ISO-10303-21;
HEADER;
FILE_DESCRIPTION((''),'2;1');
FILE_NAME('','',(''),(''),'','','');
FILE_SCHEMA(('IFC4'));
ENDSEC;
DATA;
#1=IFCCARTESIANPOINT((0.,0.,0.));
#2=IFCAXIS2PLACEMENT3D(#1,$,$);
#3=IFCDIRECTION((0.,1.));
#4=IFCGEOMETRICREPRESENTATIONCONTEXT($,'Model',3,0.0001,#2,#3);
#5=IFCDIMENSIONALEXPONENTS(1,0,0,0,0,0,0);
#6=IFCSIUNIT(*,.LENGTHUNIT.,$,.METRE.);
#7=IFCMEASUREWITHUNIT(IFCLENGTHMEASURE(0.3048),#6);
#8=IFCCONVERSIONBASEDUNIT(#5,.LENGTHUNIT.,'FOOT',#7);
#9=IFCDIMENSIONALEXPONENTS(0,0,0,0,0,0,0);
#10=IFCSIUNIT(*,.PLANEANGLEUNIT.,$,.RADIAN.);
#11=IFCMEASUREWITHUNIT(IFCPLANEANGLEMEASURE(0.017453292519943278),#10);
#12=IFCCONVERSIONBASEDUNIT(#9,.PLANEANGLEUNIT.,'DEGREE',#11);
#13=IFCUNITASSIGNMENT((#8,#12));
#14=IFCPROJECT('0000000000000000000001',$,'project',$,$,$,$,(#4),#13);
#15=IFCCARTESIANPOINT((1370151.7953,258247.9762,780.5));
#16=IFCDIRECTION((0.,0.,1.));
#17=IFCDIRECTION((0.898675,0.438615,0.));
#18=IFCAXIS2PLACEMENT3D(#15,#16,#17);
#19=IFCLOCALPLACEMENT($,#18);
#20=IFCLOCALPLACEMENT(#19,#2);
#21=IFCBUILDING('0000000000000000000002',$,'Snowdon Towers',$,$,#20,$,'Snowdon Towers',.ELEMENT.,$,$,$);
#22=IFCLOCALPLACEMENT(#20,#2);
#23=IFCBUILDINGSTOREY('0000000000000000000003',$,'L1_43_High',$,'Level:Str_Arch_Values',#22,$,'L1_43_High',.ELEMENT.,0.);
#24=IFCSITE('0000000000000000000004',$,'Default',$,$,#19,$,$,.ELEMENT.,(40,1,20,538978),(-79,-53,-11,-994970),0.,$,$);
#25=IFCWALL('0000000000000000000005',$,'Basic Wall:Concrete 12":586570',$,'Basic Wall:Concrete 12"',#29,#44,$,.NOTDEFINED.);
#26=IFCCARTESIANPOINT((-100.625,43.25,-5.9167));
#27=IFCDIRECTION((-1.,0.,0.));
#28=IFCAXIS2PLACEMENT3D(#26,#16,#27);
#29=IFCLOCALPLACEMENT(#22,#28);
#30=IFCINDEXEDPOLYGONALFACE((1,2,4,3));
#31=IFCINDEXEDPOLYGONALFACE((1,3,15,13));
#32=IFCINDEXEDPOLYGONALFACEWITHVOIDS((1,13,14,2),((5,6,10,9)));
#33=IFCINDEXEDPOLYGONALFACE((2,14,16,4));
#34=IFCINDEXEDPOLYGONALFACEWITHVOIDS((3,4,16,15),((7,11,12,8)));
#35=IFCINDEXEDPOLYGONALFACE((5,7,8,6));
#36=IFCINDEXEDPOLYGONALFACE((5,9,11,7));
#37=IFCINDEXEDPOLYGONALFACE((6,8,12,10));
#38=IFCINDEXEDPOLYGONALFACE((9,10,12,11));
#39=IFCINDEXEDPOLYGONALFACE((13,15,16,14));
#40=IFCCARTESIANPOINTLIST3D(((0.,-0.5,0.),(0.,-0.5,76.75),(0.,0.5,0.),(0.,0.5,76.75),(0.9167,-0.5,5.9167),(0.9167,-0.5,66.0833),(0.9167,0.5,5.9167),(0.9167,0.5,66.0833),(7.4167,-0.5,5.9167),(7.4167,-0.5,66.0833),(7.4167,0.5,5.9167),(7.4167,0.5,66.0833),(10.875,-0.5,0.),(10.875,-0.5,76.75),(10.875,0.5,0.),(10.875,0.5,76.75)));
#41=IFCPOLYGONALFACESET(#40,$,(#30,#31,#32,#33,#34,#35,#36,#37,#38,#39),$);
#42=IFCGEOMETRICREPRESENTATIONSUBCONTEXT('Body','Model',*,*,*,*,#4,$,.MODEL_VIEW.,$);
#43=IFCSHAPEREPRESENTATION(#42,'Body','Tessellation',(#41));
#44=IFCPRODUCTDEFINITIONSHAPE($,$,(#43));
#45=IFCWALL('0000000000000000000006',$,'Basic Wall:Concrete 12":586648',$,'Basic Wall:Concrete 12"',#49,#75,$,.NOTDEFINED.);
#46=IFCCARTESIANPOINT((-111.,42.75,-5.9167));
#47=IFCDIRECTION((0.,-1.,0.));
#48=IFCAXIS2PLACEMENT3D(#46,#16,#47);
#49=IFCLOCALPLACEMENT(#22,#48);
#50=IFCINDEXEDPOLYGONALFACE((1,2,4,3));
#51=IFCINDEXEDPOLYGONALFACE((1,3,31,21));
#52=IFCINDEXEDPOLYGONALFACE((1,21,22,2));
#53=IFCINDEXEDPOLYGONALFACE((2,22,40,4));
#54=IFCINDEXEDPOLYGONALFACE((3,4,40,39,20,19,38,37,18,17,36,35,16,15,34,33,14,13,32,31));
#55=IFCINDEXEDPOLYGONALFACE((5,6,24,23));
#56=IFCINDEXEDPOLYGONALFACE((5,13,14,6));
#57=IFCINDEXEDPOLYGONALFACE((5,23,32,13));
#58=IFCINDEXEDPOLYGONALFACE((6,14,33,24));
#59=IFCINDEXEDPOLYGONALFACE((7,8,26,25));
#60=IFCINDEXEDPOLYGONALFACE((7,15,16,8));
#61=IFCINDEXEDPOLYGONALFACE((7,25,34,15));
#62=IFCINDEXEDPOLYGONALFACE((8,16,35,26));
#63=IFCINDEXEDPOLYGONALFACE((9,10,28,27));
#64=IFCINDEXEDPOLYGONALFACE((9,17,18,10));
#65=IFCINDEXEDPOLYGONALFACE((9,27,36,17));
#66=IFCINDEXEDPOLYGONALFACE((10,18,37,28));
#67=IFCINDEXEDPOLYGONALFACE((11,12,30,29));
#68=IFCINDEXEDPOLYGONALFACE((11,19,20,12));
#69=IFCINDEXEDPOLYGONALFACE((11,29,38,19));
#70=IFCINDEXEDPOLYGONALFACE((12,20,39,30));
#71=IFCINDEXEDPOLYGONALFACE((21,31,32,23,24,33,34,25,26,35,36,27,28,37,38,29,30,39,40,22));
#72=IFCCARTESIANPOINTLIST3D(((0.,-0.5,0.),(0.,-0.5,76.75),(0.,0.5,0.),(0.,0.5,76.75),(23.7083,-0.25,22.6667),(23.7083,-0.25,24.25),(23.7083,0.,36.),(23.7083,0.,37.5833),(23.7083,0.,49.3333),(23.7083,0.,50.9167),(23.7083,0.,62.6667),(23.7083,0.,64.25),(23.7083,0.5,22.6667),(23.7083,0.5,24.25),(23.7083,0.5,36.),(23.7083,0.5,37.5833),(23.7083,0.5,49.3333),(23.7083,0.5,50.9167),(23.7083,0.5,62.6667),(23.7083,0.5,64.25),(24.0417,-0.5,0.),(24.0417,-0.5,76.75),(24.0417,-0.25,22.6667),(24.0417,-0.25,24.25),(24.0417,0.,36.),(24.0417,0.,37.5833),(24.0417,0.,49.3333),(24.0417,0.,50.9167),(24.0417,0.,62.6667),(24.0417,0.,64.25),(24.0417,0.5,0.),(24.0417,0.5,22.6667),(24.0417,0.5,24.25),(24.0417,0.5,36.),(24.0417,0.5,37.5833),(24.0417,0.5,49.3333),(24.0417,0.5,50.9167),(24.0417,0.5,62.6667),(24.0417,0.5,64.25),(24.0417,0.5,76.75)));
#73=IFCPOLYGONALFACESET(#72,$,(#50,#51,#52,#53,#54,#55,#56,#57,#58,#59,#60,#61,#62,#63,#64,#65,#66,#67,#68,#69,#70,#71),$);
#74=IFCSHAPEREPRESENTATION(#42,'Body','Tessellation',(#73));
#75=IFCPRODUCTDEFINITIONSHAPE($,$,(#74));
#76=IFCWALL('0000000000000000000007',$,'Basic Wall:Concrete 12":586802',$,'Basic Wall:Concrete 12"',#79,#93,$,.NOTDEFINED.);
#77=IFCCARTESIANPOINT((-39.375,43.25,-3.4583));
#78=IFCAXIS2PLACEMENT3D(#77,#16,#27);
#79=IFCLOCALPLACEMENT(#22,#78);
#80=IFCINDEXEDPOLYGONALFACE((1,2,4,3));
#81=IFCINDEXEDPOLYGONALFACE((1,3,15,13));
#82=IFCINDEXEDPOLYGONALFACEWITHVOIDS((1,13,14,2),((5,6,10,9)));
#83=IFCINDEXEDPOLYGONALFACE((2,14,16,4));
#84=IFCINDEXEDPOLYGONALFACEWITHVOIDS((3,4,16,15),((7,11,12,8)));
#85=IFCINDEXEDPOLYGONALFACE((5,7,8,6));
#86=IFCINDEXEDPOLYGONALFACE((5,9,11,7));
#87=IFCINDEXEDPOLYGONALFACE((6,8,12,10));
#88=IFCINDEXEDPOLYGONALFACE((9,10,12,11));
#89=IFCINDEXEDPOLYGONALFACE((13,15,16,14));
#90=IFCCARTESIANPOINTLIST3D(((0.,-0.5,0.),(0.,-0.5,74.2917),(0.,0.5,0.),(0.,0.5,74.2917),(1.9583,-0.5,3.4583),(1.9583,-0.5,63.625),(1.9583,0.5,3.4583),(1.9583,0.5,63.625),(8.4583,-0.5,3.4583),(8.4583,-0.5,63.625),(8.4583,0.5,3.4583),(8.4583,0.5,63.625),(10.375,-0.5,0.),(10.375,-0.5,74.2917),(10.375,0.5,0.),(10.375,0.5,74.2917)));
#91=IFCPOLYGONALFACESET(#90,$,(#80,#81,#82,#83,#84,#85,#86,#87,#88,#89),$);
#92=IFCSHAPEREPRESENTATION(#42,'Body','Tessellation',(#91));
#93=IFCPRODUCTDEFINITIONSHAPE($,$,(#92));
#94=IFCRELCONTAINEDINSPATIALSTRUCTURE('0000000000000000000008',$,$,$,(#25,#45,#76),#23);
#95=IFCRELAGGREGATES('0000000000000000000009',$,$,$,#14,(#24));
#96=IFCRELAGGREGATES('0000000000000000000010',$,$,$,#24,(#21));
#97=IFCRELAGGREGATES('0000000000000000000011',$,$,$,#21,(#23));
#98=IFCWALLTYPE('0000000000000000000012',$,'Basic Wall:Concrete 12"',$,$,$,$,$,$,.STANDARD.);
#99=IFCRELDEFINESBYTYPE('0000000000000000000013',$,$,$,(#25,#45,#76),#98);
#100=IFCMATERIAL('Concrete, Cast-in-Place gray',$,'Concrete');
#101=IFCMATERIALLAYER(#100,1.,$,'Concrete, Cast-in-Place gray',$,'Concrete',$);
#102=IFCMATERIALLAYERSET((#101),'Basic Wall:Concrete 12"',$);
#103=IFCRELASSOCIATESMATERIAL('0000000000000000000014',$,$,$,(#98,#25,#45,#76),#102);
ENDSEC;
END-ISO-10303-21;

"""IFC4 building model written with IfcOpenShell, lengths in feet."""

from ifc_helpers import new_model, entity, si_unit, converted_unit, direction, frame, frame_2d, origin, place, context, subcontext, project, spatial, rectangle, extrude, material, layer, layer_set, layer_usage, type_object, element, save


model = new_model("IFC4")

# Units and contexts
model_context = context("Model", 3, precision=0.0001, world=origin(), true_north=direction((0.0, 1.0)))
body_context = subcontext(model_context, "Body", "Model", "MODEL_VIEW")
ifc_project = project(units=[converted_unit("LENGTHUNIT", "FOOT", entity("IfcLengthMeasure", 0.3048), si_unit("LENGTHUNIT", "METRE"), dimensions=[1, 0, 0, 0, 0, 0, 0]), converted_unit("PLANEANGLEUNIT", "DEGREE", entity("IfcPlaneAngleMeasure", 0.017453292519943278), si_unit("PLANEANGLEUNIT", "RADIAN"), dimensions=[0, 0, 0, 0, 0, 0, 0])], contexts=[model_context])

# Site, building, storey
site_placement = place(None, frame((1370151.7953, 258247.9762, 780.5), z_axis=(0.0, 0.0, 1.0), x_axis=(0.898675, 0.438615, 0.0)))
site = spatial("IfcSite", under=ifc_project, at=site_placement, Name="Default", CompositionType="ELEMENT", RefLatitude=(40, 1, 20, 538978), RefLongitude=(-79, -53, -11, -994970), RefElevation=0.0)
building_placement = place(site_placement, origin())
building = spatial("IfcBuilding", under=site, at=building_placement, Name="Snowdon Towers", LongName="Snowdon Towers", CompositionType="ELEMENT")
storey_placement = place(building_placement, origin())
storey = spatial("IfcBuildingStorey", under=building, at=storey_placement, Name="L1_43_High", ObjectType="Level:Str_Arch_Values", LongName="L1_43_High", CompositionType="ELEMENT", Elevation=0.0)

# Wall, opening
ifc_material = material(Name="Concrete, Cast-in-Place gray", Category="Concrete")
ifc_layer = layer(ifc_material, 1.0, Name="Concrete, Cast-in-Place gray", Category="Concrete")
ifc_layer_set = layer_set([ifc_layer], Name="Basic Wall:Concrete 12\"")
ifc_layer_usage_1 = layer_usage(ifc_layer_set, "AXIS2", "POSITIVE", -0.5)
wall_type = type_object("IfcWallType", Name="Basic Wall:Concrete 12\"", PredefinedType="STANDARD", material=ifc_layer_set)
wall_1_placement = place(storey_placement, frame((-100.625, 43.25, -5.9167), z_axis=(0.0, 0.0, 1.0), x_axis=(-1.0, 0.0, 0.0)))
wall_1 = element("IfcWall", 1, at=wall_1_placement, inside=storey, type_object=wall_type, material=ifc_layer_usage_1, Name="Basic Wall:Concrete 12\":586570", ObjectType="Basic Wall:Concrete 12\"", PredefinedType="NOTDEFINED", context=body_context, shape_type="SweptSolid", body=[
    extrude(rectangle(XDim=10.875, YDim=1.0, at=frame_2d((5.4375, 0.0), x_axis=(-1.0, 0.0))), origin(), (0.0, 0.0, 1.0), 76.75),
])
opening_1_placement = place(wall_1_placement, origin())
element("IfcOpeningElement", 2, at=opening_1_placement, cuts=wall_1, PredefinedType="OPENING", context=body_context, shape_type="SweptSolid", body=[
    extrude(rectangle(XDim=60.1667, YDim=6.5, at=frame_2d((0.0, 0.0), x_axis=(1.0, 0.0))), frame((4.1667, -4.5, 36.0), z_axis=(0.0, 1.0, 0.0), x_axis=(0.0, 0.0, 1.0)), (0.0, 0.0, 1.0), 10.0),
])

# Wall, openings
ifc_layer_usage_2 = layer_usage(ifc_layer_set, "AXIS2", "POSITIVE", -0.5)
wall_2_placement = place(storey_placement, frame((-111.0, 42.75, -5.9167), z_axis=(0.0, 0.0, 1.0), x_axis=(0.0, -1.0, 0.0)))
wall_2 = element("IfcWall", 3, at=wall_2_placement, inside=storey, type_object=wall_type, material=ifc_layer_usage_2, Name="Basic Wall:Concrete 12\":586648", ObjectType="Basic Wall:Concrete 12\"", PredefinedType="NOTDEFINED", context=body_context, shape_type="SweptSolid", body=[
    extrude(rectangle(XDim=24.0417, YDim=1.0, at=frame_2d((12.0208, 0.0), x_axis=(-1.0, 0.0))), origin(), (0.0, 0.0, 1.0), 76.75),
])
opening_2_placement = place(wall_2_placement, origin())
element("IfcOpeningElement", 4, at=opening_2_placement, cuts=wall_2, PredefinedType="OPENING", context=body_context, shape_type="SweptSolid", body=[
    extrude(rectangle(XDim=1.5833, YDim=0.3333, at=frame_2d((0.0, 0.0), x_axis=(0.0, 1.0))), frame((23.875, -0.25, 23.4583), z_axis=(0.0, 1.0, 0.0), x_axis=(1.0, 0.0, 0.0)), (0.0, 0.0, 1.0), 1.0),
])
opening_3_placement = place(wall_2_placement, origin())
element("IfcOpeningElement", 5, at=opening_3_placement, cuts=wall_2, PredefinedType="OPENING", context=body_context, shape_type="SweptSolid", body=[
    extrude(rectangle(XDim=1.5833, YDim=0.3333, at=frame_2d((0.0, 0.0), x_axis=(0.0, 1.0))), frame((23.875, 0.0, 63.4583), z_axis=(0.0, 1.0, 0.0), x_axis=(1.0, 0.0, 0.0)), (0.0, 0.0, 1.0), 1.0),
])
opening_4_placement = place(wall_2_placement, origin())
element("IfcOpeningElement", 6, at=opening_4_placement, cuts=wall_2, PredefinedType="OPENING", context=body_context, shape_type="SweptSolid", body=[
    extrude(rectangle(XDim=1.5833, YDim=0.3333, at=frame_2d((0.0, 0.0), x_axis=(0.0, 1.0))), frame((23.875, 0.0, 36.7917), z_axis=(0.0, 1.0, 0.0), x_axis=(1.0, 0.0, 0.0)), (0.0, 0.0, 1.0), 1.0),
])
opening_5_placement = place(wall_2_placement, origin())
element("IfcOpeningElement", 7, at=opening_5_placement, cuts=wall_2, PredefinedType="OPENING", context=body_context, shape_type="SweptSolid", body=[
    extrude(rectangle(XDim=1.5833, YDim=0.3333, at=frame_2d((0.0, 0.0), x_axis=(0.0, 1.0))), frame((23.875, 0.0, 50.125), z_axis=(0.0, 1.0, 0.0), x_axis=(1.0, 0.0, 0.0)), (0.0, 0.0, 1.0), 1.0),
])

# Wall, opening
ifc_layer_usage_3 = layer_usage(ifc_layer_set, "AXIS2", "POSITIVE", -0.5)
wall_3_placement = place(storey_placement, frame((-39.375, 43.25, -3.4583), z_axis=(0.0, 0.0, 1.0), x_axis=(-1.0, 0.0, 0.0)))
wall_3 = element("IfcWall", 8, at=wall_3_placement, inside=storey, type_object=wall_type, material=ifc_layer_usage_3, Name="Basic Wall:Concrete 12\":586802", ObjectType="Basic Wall:Concrete 12\"", PredefinedType="NOTDEFINED", context=body_context, shape_type="SweptSolid", body=[
    extrude(rectangle(XDim=10.375, YDim=1.0, at=frame_2d((5.1875, 0.0), x_axis=(-1.0, 0.0))), origin(), (0.0, 0.0, 1.0), 74.2917),
])
opening_6_placement = place(wall_3_placement, origin())
element("IfcOpeningElement", 9, at=opening_6_placement, cuts=wall_3, PredefinedType="OPENING", context=body_context, shape_type="SweptSolid", body=[
    extrude(rectangle(XDim=60.1667, YDim=6.5, at=frame_2d((0.0, 0.0), x_axis=(1.0, 0.0))), frame((5.2083, -4.5, 33.5417), z_axis=(0.0, 1.0, 0.0), x_axis=(0.0, 0.0, 1.0)), (0.0, 0.0, 1.0), 10.0),
])

save(model, "model.ifc")
